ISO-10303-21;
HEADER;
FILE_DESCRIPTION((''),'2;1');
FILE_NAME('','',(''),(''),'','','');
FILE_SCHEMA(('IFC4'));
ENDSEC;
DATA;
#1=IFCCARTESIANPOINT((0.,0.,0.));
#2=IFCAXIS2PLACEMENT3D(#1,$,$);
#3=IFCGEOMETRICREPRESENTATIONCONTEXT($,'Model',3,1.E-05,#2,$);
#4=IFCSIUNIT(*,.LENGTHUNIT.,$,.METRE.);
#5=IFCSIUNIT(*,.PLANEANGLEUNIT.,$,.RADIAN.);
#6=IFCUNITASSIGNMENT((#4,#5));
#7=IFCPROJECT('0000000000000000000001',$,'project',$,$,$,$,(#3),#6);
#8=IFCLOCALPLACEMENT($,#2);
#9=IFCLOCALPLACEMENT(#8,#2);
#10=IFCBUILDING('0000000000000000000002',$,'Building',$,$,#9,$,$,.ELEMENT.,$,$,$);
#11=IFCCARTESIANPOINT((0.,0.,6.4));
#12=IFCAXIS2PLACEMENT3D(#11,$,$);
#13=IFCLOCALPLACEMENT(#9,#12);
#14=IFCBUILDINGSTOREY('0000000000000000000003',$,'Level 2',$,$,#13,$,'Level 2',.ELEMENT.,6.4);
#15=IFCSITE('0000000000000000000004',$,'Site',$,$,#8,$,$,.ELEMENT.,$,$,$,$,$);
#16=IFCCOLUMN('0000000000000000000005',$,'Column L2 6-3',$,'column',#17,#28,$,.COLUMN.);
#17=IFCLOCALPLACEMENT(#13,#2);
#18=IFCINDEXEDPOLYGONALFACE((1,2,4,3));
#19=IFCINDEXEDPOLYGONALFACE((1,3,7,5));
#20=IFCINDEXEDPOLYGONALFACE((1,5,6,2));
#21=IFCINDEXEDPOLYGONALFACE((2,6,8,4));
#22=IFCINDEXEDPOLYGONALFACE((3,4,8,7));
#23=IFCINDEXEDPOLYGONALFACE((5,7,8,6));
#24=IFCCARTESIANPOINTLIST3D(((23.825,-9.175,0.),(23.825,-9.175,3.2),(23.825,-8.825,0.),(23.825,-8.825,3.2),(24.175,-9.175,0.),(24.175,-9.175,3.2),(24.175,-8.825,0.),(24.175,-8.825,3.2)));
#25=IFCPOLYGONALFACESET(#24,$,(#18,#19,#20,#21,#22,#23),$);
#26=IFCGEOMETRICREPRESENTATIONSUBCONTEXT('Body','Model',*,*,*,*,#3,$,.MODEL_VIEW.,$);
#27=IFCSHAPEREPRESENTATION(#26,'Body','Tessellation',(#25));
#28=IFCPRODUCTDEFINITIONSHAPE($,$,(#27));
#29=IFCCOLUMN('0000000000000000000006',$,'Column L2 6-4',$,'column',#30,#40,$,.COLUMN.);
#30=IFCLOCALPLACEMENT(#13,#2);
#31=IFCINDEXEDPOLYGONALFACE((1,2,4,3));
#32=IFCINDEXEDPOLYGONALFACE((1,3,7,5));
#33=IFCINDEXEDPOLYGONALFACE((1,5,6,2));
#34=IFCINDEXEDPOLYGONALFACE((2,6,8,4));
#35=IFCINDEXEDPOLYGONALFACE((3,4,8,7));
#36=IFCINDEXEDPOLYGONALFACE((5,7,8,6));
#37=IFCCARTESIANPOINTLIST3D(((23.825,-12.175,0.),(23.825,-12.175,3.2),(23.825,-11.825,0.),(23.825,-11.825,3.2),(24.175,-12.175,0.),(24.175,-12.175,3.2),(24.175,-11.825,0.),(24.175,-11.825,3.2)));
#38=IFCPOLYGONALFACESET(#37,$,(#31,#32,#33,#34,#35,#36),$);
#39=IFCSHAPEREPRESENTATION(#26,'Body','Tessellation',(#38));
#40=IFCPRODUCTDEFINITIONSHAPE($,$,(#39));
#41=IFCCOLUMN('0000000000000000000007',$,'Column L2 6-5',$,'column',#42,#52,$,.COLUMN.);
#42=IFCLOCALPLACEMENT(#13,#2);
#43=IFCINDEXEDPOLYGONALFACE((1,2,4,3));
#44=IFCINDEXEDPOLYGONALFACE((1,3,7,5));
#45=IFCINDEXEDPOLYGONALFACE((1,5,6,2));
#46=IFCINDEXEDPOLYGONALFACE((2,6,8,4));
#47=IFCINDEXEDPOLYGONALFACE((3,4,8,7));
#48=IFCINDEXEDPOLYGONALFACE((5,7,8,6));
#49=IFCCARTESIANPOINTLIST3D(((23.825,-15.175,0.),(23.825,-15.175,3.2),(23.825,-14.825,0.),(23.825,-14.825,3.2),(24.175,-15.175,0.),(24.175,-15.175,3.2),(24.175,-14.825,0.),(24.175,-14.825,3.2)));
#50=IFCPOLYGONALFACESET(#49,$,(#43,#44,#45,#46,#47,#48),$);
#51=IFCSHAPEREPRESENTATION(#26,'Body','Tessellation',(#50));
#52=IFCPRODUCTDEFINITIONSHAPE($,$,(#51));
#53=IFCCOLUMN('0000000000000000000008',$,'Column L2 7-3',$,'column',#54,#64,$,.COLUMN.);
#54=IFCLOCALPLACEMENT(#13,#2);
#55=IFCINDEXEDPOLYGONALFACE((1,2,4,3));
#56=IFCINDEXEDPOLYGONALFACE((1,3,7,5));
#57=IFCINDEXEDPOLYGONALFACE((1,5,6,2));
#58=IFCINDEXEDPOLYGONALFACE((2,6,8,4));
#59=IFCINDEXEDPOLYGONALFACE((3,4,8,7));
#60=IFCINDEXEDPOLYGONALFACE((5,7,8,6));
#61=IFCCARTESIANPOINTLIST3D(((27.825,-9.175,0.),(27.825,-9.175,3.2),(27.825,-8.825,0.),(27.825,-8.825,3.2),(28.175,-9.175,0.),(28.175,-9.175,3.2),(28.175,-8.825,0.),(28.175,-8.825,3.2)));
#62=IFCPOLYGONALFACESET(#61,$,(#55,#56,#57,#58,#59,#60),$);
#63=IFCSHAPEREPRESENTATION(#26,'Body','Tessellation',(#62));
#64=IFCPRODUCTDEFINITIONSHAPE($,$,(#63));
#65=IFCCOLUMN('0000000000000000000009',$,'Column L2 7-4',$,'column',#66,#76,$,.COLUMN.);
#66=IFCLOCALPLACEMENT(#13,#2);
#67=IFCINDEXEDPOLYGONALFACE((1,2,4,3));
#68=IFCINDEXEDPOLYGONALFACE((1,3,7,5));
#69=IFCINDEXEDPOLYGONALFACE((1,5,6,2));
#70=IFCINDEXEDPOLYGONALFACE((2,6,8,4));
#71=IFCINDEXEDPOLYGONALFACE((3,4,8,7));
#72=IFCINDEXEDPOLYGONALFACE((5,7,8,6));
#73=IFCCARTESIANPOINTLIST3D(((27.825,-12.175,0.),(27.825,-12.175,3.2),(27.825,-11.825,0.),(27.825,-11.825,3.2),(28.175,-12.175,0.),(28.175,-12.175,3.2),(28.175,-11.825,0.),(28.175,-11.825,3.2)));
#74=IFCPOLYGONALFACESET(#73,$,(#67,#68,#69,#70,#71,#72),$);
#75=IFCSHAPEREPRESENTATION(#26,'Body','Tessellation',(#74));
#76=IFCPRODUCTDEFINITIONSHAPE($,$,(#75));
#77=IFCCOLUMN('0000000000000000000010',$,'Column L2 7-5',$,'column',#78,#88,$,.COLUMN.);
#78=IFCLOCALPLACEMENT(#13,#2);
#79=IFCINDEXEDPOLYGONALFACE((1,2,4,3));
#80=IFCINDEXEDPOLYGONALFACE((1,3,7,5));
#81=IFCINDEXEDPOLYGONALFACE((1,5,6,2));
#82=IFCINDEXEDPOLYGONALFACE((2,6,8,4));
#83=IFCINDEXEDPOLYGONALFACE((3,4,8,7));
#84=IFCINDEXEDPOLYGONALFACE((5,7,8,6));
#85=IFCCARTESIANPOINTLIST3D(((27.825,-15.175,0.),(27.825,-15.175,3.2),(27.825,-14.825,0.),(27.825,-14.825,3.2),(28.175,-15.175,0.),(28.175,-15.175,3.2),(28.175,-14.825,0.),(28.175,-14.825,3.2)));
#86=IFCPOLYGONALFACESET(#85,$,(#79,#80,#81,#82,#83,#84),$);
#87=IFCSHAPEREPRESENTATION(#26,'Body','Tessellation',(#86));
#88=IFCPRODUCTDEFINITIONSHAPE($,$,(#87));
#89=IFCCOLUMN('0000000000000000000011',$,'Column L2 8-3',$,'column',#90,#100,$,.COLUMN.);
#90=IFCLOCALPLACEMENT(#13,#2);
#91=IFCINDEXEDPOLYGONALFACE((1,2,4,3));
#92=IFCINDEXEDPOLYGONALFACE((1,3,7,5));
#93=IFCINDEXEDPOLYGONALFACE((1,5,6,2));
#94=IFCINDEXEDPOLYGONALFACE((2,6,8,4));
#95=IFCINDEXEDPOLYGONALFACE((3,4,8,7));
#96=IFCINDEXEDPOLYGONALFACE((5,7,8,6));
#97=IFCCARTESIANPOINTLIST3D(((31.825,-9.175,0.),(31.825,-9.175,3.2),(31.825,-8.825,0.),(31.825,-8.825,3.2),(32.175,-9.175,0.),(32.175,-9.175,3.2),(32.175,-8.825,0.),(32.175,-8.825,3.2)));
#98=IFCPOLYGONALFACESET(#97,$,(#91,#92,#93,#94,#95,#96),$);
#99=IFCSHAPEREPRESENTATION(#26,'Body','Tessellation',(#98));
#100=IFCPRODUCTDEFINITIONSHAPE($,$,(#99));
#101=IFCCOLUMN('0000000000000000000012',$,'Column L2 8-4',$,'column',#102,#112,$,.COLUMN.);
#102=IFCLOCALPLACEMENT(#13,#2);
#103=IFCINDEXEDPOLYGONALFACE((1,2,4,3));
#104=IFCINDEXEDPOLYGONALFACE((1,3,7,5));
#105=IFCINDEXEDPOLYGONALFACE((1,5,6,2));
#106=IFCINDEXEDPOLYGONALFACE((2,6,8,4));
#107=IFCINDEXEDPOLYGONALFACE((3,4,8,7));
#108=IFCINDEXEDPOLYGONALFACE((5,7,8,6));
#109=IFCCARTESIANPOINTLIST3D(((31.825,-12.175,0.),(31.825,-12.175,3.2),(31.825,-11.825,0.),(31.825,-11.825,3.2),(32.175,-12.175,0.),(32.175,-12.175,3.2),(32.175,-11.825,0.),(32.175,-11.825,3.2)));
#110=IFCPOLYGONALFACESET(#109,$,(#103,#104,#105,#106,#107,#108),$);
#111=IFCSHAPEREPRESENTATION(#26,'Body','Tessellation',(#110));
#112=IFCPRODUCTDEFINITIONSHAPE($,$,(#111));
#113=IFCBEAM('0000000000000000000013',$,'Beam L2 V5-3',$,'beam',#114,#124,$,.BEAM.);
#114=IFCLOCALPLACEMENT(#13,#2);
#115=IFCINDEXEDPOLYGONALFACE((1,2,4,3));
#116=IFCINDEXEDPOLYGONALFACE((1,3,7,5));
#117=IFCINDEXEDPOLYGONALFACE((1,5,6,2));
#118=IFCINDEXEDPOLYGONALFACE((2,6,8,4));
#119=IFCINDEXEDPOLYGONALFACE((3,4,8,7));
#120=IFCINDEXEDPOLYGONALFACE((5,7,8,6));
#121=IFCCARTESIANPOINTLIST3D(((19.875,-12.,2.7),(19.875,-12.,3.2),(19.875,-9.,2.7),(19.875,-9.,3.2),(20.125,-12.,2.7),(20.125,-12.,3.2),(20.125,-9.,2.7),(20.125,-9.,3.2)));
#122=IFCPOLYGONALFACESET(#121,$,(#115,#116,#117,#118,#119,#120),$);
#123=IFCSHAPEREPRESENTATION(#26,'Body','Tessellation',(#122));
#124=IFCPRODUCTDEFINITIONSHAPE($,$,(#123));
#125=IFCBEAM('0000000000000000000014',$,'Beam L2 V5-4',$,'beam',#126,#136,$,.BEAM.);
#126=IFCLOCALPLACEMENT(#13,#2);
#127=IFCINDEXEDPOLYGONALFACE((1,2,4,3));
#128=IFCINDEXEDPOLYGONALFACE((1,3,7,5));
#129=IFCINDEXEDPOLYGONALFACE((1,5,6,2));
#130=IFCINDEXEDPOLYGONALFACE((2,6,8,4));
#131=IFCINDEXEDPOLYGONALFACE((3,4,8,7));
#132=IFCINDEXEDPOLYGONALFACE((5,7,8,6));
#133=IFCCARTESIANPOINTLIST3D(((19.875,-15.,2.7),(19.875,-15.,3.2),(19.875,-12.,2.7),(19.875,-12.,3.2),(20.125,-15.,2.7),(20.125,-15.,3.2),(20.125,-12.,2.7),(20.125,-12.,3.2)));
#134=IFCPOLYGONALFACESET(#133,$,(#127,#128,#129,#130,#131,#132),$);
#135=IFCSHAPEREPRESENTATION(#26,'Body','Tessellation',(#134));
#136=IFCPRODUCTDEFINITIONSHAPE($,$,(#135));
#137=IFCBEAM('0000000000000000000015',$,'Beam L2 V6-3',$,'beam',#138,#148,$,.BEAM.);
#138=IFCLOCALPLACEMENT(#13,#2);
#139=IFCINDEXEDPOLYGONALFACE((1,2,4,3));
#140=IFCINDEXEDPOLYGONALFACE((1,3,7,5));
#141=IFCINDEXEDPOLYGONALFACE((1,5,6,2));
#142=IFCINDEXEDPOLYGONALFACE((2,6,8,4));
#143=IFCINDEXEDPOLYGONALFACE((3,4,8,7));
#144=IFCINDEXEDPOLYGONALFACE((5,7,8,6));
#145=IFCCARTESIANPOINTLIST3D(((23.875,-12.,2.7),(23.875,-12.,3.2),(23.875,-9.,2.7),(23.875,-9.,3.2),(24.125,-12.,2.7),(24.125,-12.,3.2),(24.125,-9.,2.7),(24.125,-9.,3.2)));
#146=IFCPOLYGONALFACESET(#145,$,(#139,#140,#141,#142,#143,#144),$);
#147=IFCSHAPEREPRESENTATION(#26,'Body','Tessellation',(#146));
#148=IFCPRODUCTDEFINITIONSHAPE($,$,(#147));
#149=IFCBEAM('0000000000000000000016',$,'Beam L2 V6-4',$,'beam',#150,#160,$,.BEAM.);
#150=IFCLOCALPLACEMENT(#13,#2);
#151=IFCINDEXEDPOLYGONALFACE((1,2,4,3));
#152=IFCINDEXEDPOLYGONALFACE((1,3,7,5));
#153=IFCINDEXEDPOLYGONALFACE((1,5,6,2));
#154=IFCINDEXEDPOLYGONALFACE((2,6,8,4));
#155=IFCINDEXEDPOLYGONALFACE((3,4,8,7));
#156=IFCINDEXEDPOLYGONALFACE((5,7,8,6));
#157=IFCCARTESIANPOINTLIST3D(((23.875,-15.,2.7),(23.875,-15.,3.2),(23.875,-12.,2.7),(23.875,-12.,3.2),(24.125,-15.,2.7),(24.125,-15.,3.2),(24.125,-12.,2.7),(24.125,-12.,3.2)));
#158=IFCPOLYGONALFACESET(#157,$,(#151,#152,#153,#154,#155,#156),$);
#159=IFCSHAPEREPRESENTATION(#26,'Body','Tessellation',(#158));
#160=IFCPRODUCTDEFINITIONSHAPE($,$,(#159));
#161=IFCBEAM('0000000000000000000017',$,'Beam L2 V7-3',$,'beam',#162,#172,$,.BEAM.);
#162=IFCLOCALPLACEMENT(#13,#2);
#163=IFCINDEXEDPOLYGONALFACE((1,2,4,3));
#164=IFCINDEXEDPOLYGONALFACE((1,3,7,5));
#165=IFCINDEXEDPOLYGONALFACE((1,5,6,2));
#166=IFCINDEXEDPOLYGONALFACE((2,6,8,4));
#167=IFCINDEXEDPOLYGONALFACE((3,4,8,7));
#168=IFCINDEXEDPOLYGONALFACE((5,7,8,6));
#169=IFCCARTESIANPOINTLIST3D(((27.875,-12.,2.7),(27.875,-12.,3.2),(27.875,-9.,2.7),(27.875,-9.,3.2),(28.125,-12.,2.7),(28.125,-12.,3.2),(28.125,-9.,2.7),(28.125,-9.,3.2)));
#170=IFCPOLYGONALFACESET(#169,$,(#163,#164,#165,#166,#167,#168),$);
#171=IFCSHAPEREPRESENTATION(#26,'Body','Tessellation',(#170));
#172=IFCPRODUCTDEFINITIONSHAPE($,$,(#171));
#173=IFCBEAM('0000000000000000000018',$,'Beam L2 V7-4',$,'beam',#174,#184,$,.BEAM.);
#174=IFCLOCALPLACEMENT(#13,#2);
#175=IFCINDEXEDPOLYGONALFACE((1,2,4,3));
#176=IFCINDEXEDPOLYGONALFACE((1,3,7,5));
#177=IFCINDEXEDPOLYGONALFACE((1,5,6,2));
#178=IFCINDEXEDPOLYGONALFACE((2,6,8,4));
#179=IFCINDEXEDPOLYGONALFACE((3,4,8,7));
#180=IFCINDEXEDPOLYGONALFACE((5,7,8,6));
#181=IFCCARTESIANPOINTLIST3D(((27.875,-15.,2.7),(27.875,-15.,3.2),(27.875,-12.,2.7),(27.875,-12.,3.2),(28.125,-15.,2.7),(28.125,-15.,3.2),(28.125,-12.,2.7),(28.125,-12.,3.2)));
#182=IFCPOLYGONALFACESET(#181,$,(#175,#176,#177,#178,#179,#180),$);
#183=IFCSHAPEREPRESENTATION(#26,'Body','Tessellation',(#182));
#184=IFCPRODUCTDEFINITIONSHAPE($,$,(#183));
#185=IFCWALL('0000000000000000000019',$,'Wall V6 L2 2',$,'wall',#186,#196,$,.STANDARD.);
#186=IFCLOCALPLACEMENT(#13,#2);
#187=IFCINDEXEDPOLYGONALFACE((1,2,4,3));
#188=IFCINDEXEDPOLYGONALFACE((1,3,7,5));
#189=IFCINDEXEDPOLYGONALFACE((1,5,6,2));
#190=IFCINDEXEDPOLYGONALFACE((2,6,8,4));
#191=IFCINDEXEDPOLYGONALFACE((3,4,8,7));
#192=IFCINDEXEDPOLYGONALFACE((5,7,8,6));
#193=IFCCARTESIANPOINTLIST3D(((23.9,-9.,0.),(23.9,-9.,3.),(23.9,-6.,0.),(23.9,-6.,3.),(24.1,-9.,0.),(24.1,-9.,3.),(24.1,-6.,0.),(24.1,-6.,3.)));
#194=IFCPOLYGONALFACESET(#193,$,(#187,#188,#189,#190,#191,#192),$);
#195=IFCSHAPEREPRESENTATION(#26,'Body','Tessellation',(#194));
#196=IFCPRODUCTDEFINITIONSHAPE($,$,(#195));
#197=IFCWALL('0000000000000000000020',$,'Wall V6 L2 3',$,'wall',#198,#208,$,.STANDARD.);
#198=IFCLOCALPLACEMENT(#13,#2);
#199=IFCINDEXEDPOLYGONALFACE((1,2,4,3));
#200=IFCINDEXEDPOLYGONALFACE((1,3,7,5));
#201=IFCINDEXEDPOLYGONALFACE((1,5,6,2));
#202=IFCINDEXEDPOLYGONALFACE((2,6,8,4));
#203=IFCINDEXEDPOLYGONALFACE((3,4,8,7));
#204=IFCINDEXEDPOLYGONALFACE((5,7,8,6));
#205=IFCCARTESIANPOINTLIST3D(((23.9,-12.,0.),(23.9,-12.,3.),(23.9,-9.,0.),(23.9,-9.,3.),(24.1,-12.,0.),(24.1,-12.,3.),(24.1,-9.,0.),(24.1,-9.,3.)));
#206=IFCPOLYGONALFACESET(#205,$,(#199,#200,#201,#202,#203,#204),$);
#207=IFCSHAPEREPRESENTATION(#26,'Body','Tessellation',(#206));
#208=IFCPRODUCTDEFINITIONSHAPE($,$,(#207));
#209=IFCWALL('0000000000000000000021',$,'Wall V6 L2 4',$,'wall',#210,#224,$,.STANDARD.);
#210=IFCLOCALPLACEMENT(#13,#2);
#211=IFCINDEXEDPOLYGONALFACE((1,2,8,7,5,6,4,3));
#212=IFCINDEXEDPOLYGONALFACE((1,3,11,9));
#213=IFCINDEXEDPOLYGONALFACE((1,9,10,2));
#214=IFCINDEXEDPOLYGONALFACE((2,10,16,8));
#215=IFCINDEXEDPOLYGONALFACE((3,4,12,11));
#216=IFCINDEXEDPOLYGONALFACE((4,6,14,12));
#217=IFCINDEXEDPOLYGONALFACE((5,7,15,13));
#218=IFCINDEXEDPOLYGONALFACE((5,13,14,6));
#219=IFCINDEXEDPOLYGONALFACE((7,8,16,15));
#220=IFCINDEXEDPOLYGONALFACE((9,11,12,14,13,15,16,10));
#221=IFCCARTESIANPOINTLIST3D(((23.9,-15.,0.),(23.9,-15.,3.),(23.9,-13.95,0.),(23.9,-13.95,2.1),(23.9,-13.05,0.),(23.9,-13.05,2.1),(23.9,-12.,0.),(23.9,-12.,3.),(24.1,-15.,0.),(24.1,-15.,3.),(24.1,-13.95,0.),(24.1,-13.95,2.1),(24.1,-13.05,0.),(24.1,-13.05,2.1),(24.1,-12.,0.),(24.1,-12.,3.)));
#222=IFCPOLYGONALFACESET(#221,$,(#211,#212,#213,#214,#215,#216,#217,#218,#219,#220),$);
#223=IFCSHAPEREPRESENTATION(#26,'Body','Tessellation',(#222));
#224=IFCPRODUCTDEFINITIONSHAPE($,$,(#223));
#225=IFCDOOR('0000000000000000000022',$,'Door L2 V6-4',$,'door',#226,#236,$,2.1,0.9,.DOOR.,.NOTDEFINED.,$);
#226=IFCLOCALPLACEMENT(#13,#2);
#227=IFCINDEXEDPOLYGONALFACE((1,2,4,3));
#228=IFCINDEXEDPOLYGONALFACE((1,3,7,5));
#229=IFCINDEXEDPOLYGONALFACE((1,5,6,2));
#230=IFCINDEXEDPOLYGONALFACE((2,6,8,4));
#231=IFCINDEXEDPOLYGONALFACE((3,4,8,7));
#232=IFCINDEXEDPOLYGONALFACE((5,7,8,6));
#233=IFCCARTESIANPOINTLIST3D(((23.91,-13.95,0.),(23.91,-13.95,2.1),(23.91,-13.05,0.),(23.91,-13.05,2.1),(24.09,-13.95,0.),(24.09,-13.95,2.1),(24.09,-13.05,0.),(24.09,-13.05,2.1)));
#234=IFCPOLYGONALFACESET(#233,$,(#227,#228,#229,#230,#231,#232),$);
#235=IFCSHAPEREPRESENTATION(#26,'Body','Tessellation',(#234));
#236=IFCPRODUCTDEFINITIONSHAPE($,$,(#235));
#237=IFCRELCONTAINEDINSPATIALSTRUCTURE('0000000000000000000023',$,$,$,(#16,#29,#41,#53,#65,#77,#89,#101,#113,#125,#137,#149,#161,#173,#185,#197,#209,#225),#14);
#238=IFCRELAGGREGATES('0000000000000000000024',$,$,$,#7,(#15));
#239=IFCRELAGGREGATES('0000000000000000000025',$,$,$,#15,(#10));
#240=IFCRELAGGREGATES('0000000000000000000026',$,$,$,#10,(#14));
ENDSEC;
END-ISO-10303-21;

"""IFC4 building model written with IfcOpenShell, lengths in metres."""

from ifc_helpers import new_model, si_unit, frame, frame_2d, origin, origin_2d, place, context, subcontext, project, spatial, rectangle, extrude, element, fill, save


model = new_model("IFC4")

# Units and contexts
model_context = context("Model", 3, precision=1e-05, world=origin())
body_context = subcontext(model_context, "Body", "Model", "MODEL_VIEW")
ifc_project = project(units=[si_unit("LENGTHUNIT", "METRE"), si_unit("PLANEANGLEUNIT", "RADIAN")], contexts=[model_context])

# Site, building, storey
site_placement = place(None, origin())
site = spatial("IfcSite", under=ifc_project, at=site_placement, Name="Site", CompositionType="ELEMENT")
building_placement = place(site_placement, origin())
building = spatial("IfcBuilding", under=site, at=building_placement, Name="Building", CompositionType="ELEMENT")
storey_placement = place(building_placement, frame((0.0, 0.0, 6.4)))
storey = spatial("IfcBuildingStorey", under=building, at=storey_placement, Name="Level 2", LongName="Level 2", CompositionType="ELEMENT", Elevation=6.4)

# Columns
for number, where, name in (
    (1, (24.0, -9.0, 0.0), "Column L2 6-3"),
    (2, (24.0, -12.0, 0.0), "Column L2 6-4"),
    (3, (24.0, -15.0, 0.0), "Column L2 6-5"),
    (4, (28.0, -9.0, 0.0), "Column L2 7-3"),
    (5, (28.0, -12.0, 0.0), "Column L2 7-4"),
    (6, (28.0, -15.0, 0.0), "Column L2 7-5"),
    (7, (32.0, -9.0, 0.0), "Column L2 8-3"),
    (8, (32.0, -12.0, 0.0), "Column L2 8-4"),
):
    element("IfcColumn", number, at=place(storey_placement, frame(where)), inside=storey, Name=name, ObjectType="column", PredefinedType="COLUMN", context=body_context, shape_type="SweptSolid", body=[
        extrude(rectangle(XDim=0.35, YDim=0.35, at=origin_2d()), origin(), (0.0, 0.0, 1.0), 3.2),
    ])

# Beams
for number, where, z_axis, x_axis, name in (
    (9, (20.0, -9.0, 2.95), (0.0, -1.0, 0.0), (0.0, 0.0, 1.0), "Beam L2 V5-3"),
    (10, (20.0, -12.0, 2.95), (0.0, -1.0, 0.0), (0.0, 0.0, 1.0), "Beam L2 V5-4"),
    (11, (24.0, -9.0, 2.95), (0.0, -1.0, 0.0), (0.0, 0.0, 1.0), "Beam L2 V6-3"),
    (12, (24.0, -12.0, 2.95), (0.0, -1.0, 0.0), (0.0, 0.0, 1.0), "Beam L2 V6-4"),
    (13, (28.0, -9.0, 2.95), (0.0, -1.0, 0.0), (0.0, 0.0, 1.0), "Beam L2 V7-3"),
    (14, (28.0, -12.0, 2.95), (0.0, -1.0, 0.0), (0.0, 0.0, 1.0), "Beam L2 V7-4"),
):
    element("IfcBeam", number, at=place(storey_placement, frame(where, z_axis=z_axis, x_axis=x_axis)), inside=storey, Name=name, ObjectType="beam", PredefinedType="BEAM", context=body_context, shape_type="SweptSolid", body=[
        extrude(rectangle(XDim=0.5, YDim=0.25, at=origin_2d()), origin(), (0.0, 0.0, 1.0), 3.0),
    ])

# Walls
for number, where, z_axis, x_axis, name in (
    (15, (24.0, -6.0, 0.0), (0.0, 0.0, 1.0), (0.0, -1.0, 0.0), "Wall V6 L2 2"),
    (16, (24.0, -9.0, 0.0), (0.0, 0.0, 1.0), (0.0, -1.0, 0.0), "Wall V6 L2 3"),
):
    element("IfcWall", number, at=place(storey_placement, frame(where, z_axis=z_axis, x_axis=x_axis)), inside=storey, Name=name, ObjectType="wall", PredefinedType="STANDARD", context=body_context, shape_type="SweptSolid", body=[
        extrude(rectangle(XDim=3.0, YDim=0.2, at=frame_2d((1.5, 0.0))), origin(), (0.0, 0.0, 1.0), 3.0),
    ])

# Wall, opening, door
wall_1_placement = place(storey_placement, frame((24.0, -12.0, 0.0), z_axis=(0.0, 0.0, 1.0), x_axis=(0.0, -1.0, 0.0)))
wall_1 = element("IfcWall", 17, at=wall_1_placement, inside=storey, Name="Wall V6 L2 4", ObjectType="wall", PredefinedType="STANDARD", context=body_context, shape_type="SweptSolid", body=[
    extrude(rectangle(XDim=3.0, YDim=0.2, at=frame_2d((1.5, 0.0))), origin(), (0.0, 0.0, 1.0), 3.0),
])
opening_1_placement = place(storey_placement, frame((24.0, -13.5, 0.0), z_axis=(0.0, 0.0, 1.0), x_axis=(0.0, -1.0, 0.0)))
opening_1 = element("IfcOpeningElement", 18, at=opening_1_placement, cuts=wall_1, ObjectType="Opening", PredefinedType="OPENING", context=body_context, shape_type="SweptSolid", body=[
    extrude(rectangle(XDim=0.9, YDim=0.22, at=origin_2d()), origin(), (0.0, 0.0, 1.0), 2.1),
])
door_1_placement = place(storey_placement, frame((24.0, -13.5, 0.0), z_axis=(0.0, 0.0, 1.0), x_axis=(0.0, -1.0, 0.0)))
door_1 = element("IfcDoor", 19, at=door_1_placement, inside=storey, Name="Door L2 V6-4", ObjectType="door", OperationType="NOTDEFINED", OverallHeight=2.1, OverallWidth=0.9, PredefinedType="DOOR", context=body_context, shape_type="SweptSolid", body=[
    extrude(rectangle(XDim=0.9, YDim=0.18, at=origin_2d()), origin(), (0.0, 0.0, 1.0), 2.1),
])
fill(opening_1, door_1)

save(model, "model.ifc")
